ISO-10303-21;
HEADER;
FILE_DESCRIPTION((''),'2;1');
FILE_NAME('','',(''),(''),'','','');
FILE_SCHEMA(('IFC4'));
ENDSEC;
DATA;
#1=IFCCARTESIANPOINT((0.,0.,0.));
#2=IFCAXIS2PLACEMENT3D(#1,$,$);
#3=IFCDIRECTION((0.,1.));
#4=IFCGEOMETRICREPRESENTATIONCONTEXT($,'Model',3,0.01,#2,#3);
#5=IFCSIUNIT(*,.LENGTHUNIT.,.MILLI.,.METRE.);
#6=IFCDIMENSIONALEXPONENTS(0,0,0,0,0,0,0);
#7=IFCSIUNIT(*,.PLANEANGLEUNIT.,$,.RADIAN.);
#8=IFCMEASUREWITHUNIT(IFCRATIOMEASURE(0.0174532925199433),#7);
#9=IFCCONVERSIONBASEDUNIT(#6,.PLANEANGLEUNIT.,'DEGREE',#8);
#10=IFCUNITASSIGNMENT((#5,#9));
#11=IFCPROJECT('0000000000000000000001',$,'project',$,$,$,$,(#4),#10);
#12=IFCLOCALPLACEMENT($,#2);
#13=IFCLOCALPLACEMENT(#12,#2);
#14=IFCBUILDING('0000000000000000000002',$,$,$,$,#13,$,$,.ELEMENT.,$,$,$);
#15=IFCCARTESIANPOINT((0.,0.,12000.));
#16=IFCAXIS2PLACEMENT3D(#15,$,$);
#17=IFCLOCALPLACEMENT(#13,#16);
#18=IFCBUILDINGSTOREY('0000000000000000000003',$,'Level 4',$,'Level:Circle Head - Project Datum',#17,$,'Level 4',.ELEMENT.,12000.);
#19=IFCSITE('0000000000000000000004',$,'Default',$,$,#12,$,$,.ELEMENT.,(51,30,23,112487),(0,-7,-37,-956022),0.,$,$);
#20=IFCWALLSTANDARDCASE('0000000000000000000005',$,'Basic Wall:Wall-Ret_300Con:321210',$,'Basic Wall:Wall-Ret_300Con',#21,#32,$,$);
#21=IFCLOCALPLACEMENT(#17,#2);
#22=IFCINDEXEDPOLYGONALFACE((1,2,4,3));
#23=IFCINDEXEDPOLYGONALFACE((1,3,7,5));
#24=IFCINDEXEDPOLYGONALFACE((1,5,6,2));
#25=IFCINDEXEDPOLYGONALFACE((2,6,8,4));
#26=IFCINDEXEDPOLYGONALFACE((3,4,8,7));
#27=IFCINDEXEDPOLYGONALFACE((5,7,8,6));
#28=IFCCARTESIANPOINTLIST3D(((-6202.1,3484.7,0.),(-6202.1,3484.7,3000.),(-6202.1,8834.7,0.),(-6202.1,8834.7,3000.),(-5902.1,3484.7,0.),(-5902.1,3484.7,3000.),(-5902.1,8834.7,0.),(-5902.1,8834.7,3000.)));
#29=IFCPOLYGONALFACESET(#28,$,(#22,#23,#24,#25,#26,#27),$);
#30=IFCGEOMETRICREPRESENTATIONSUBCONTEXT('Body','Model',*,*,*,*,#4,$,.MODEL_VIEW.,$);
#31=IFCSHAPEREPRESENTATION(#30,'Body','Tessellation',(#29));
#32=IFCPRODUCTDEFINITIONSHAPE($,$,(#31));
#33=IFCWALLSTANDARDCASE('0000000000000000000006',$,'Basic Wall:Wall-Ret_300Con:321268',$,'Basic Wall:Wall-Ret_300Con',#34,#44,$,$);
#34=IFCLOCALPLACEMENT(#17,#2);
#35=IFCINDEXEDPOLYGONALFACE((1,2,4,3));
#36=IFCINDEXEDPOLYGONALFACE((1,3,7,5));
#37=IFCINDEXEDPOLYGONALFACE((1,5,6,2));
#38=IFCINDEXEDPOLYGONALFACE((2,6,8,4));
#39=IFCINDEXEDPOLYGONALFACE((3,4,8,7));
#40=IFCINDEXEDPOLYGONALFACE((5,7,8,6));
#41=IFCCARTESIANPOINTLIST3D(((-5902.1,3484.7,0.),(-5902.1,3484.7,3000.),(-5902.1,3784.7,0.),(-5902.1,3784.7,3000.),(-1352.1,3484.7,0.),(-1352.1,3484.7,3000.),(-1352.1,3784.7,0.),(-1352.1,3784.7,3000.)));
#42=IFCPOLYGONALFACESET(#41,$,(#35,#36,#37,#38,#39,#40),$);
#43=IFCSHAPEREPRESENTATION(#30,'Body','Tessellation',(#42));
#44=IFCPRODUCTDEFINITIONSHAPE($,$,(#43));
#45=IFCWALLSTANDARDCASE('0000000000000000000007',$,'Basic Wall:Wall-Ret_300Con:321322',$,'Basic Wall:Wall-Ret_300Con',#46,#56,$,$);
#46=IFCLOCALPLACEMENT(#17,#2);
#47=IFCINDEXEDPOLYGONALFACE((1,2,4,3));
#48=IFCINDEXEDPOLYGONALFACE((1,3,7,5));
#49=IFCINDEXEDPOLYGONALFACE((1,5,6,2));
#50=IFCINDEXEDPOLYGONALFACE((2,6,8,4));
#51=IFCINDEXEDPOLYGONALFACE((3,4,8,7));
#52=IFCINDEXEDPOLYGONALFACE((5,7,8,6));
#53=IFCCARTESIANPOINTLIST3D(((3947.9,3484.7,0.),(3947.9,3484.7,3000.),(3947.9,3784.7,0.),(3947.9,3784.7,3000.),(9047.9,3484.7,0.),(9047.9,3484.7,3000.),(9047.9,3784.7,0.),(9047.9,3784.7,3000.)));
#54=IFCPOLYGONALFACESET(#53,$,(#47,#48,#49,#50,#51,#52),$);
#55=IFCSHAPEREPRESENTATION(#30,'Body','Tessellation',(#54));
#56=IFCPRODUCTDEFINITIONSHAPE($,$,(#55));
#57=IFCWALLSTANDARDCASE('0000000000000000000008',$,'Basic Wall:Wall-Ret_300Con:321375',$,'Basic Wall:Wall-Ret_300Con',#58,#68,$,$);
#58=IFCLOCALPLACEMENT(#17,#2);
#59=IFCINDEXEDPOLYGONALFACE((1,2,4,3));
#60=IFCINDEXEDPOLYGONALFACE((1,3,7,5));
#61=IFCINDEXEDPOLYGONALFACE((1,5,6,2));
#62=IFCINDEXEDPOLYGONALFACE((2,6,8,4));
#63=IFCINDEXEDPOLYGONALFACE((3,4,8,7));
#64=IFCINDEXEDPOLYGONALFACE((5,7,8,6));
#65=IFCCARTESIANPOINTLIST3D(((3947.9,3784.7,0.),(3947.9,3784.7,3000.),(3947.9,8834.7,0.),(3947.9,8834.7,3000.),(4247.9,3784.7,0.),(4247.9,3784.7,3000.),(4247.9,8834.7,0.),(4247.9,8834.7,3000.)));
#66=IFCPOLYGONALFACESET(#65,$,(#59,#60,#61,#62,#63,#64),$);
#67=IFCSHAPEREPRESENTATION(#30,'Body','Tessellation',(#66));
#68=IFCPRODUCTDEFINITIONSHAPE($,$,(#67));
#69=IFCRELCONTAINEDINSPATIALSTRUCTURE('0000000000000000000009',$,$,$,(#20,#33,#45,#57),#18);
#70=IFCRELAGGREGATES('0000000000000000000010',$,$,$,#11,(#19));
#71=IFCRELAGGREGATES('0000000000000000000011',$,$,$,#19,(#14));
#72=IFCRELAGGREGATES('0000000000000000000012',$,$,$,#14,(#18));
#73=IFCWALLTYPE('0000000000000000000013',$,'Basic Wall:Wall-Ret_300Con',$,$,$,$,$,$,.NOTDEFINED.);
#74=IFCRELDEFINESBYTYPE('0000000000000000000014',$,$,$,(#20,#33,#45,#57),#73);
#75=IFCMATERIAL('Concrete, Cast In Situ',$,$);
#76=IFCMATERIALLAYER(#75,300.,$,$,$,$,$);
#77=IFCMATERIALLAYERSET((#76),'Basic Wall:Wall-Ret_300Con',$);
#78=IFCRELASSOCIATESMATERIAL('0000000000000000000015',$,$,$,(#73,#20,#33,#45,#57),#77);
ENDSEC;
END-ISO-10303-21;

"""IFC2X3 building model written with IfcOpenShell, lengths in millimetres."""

from ifc_helpers import new_model, entity, si_unit, converted_unit, direction, frame, frame_2d, origin, place, context, subcontext, project, spatial, rectangle, extrude, material, layer, layer_set, layer_usage, type_object, element, save


model = new_model("IFC2X3")

# Units and contexts
model_context = context("Model", 3, precision=0.01, world=origin(), true_north=direction((0.0, 1.0)))
body_context = subcontext(model_context, "Body", "Model", "MODEL_VIEW")
ifc_project = project(units=[si_unit("LENGTHUNIT", "METRE", prefix="MILLI"), converted_unit("PLANEANGLEUNIT", "DEGREE", entity("IfcRatioMeasure", 0.0174532925199433), si_unit("PLANEANGLEUNIT", "RADIAN"), dimensions=[0, 0, 0, 0, 0, 0, 0])], contexts=[model_context])

# Site, building, storey
site_placement = place(None, origin())
site = spatial("IfcSite", under=ifc_project, at=site_placement, Name="Default", CompositionType="ELEMENT", RefLatitude=(51, 30, 23, 112487), RefLongitude=(0, -7, -37, -956022), RefElevation=0.0)
building_placement = place(site_placement, origin())
building = spatial("IfcBuilding", under=site, at=building_placement, CompositionType="ELEMENT")
storey_placement = place(building_placement, frame((0.0, 0.0, 12000.0)))
storey = spatial("IfcBuildingStorey", under=building, at=storey_placement, Name="Level 4", ObjectType="Level:Circle Head - Project Datum", LongName="Level 4", CompositionType="ELEMENT", Elevation=12000.0)

# Walls
ifc_material_1 = material(Name="Concrete, Cast In Situ")
ifc_layer_1 = layer(ifc_material_1, 300.0)
ifc_layer_set_1 = layer_set([ifc_layer_1], Name="Basic Wall:Wall-Ret_300Con")
wall_type = type_object("IfcWallType", Name="Basic Wall:Wall-Ret_300Con", PredefinedType="NOTDEFINED", material=ifc_layer_set_1)
ifc_layer_usage_1 = layer_usage(ifc_layer_set_1, "AXIS2", "NEGATIVE", 150.0)
wall_1_placement = place(storey_placement, frame((-6052.1, 8834.7, 0.0), z_axis=(0.0, 0.0, 1.0), x_axis=(0.0, -1.0, 0.0)))
element("IfcWallStandardCase", 1, at=wall_1_placement, inside=storey, type_object=wall_type, material=ifc_layer_usage_1, Name="Basic Wall:Wall-Ret_300Con:321210", ObjectType="Basic Wall:Wall-Ret_300Con", context=body_context, shape_type="SweptSolid", body=[
    extrude(rectangle(XDim=5350.0, YDim=300.0, at=frame_2d((2675.0, 0.0), x_axis=(-1.0, 0.0))), origin(), (0.0, 0.0, 1.0), 3000.0),
])
ifc_layer_usage_2 = layer_usage(ifc_layer_set_1, "AXIS2", "NEGATIVE", 150.0)
wall_2_placement = place(storey_placement, frame((-5902.1, 3634.7, 0.0)))
element("IfcWallStandardCase", 2, at=wall_2_placement, inside=storey, type_object=wall_type, material=ifc_layer_usage_2, Name="Basic Wall:Wall-Ret_300Con:321268", ObjectType="Basic Wall:Wall-Ret_300Con", context=body_context, shape_type="SweptSolid", body=[
    extrude(rectangle(XDim=4550.0, YDim=300.0, at=frame_2d((2275.0, 0.0), x_axis=(-1.0, 0.0))), origin(), (0.0, 0.0, 1.0), 3000.0),
])
ifc_layer_usage_3 = layer_usage(ifc_layer_set_1, "AXIS2", "NEGATIVE", 150.0)
wall_3_placement = place(storey_placement, frame((9047.9, 3634.7, 0.0), z_axis=(0.0, 0.0, 1.0), x_axis=(-1.0, 0.0, 0.0)))
element("IfcWallStandardCase", 3, at=wall_3_placement, inside=storey, type_object=wall_type, material=ifc_layer_usage_3, Name="Basic Wall:Wall-Ret_300Con:321322", ObjectType="Basic Wall:Wall-Ret_300Con", context=body_context, shape_type="SweptSolid", body=[
    extrude(rectangle(XDim=5100.0, YDim=300.0, at=frame_2d((2550.0, 0.0), x_axis=(-1.0, 0.0))), origin(), (0.0, 0.0, 1.0), 3000.0),
])
ifc_layer_usage_4 = layer_usage(ifc_layer_set_1, "AXIS2", "NEGATIVE", 150.0)
wall_4_placement = place(storey_placement, frame((4097.9, 3784.7, 0.0), z_axis=(0.0, 0.0, 1.0), x_axis=(0.0, 1.0, 0.0)))
element("IfcWallStandardCase", 4, at=wall_4_placement, inside=storey, type_object=wall_type, material=ifc_layer_usage_4, Name="Basic Wall:Wall-Ret_300Con:321375", ObjectType="Basic Wall:Wall-Ret_300Con", context=body_context, shape_type="SweptSolid", body=[
    extrude(rectangle(XDim=5050.0, YDim=300.0, at=frame_2d((2525.0, 0.0), x_axis=(-1.0, 0.0))), origin(), (0.0, 0.0, 1.0), 3000.0),
])

save(model, "model.ifc")
